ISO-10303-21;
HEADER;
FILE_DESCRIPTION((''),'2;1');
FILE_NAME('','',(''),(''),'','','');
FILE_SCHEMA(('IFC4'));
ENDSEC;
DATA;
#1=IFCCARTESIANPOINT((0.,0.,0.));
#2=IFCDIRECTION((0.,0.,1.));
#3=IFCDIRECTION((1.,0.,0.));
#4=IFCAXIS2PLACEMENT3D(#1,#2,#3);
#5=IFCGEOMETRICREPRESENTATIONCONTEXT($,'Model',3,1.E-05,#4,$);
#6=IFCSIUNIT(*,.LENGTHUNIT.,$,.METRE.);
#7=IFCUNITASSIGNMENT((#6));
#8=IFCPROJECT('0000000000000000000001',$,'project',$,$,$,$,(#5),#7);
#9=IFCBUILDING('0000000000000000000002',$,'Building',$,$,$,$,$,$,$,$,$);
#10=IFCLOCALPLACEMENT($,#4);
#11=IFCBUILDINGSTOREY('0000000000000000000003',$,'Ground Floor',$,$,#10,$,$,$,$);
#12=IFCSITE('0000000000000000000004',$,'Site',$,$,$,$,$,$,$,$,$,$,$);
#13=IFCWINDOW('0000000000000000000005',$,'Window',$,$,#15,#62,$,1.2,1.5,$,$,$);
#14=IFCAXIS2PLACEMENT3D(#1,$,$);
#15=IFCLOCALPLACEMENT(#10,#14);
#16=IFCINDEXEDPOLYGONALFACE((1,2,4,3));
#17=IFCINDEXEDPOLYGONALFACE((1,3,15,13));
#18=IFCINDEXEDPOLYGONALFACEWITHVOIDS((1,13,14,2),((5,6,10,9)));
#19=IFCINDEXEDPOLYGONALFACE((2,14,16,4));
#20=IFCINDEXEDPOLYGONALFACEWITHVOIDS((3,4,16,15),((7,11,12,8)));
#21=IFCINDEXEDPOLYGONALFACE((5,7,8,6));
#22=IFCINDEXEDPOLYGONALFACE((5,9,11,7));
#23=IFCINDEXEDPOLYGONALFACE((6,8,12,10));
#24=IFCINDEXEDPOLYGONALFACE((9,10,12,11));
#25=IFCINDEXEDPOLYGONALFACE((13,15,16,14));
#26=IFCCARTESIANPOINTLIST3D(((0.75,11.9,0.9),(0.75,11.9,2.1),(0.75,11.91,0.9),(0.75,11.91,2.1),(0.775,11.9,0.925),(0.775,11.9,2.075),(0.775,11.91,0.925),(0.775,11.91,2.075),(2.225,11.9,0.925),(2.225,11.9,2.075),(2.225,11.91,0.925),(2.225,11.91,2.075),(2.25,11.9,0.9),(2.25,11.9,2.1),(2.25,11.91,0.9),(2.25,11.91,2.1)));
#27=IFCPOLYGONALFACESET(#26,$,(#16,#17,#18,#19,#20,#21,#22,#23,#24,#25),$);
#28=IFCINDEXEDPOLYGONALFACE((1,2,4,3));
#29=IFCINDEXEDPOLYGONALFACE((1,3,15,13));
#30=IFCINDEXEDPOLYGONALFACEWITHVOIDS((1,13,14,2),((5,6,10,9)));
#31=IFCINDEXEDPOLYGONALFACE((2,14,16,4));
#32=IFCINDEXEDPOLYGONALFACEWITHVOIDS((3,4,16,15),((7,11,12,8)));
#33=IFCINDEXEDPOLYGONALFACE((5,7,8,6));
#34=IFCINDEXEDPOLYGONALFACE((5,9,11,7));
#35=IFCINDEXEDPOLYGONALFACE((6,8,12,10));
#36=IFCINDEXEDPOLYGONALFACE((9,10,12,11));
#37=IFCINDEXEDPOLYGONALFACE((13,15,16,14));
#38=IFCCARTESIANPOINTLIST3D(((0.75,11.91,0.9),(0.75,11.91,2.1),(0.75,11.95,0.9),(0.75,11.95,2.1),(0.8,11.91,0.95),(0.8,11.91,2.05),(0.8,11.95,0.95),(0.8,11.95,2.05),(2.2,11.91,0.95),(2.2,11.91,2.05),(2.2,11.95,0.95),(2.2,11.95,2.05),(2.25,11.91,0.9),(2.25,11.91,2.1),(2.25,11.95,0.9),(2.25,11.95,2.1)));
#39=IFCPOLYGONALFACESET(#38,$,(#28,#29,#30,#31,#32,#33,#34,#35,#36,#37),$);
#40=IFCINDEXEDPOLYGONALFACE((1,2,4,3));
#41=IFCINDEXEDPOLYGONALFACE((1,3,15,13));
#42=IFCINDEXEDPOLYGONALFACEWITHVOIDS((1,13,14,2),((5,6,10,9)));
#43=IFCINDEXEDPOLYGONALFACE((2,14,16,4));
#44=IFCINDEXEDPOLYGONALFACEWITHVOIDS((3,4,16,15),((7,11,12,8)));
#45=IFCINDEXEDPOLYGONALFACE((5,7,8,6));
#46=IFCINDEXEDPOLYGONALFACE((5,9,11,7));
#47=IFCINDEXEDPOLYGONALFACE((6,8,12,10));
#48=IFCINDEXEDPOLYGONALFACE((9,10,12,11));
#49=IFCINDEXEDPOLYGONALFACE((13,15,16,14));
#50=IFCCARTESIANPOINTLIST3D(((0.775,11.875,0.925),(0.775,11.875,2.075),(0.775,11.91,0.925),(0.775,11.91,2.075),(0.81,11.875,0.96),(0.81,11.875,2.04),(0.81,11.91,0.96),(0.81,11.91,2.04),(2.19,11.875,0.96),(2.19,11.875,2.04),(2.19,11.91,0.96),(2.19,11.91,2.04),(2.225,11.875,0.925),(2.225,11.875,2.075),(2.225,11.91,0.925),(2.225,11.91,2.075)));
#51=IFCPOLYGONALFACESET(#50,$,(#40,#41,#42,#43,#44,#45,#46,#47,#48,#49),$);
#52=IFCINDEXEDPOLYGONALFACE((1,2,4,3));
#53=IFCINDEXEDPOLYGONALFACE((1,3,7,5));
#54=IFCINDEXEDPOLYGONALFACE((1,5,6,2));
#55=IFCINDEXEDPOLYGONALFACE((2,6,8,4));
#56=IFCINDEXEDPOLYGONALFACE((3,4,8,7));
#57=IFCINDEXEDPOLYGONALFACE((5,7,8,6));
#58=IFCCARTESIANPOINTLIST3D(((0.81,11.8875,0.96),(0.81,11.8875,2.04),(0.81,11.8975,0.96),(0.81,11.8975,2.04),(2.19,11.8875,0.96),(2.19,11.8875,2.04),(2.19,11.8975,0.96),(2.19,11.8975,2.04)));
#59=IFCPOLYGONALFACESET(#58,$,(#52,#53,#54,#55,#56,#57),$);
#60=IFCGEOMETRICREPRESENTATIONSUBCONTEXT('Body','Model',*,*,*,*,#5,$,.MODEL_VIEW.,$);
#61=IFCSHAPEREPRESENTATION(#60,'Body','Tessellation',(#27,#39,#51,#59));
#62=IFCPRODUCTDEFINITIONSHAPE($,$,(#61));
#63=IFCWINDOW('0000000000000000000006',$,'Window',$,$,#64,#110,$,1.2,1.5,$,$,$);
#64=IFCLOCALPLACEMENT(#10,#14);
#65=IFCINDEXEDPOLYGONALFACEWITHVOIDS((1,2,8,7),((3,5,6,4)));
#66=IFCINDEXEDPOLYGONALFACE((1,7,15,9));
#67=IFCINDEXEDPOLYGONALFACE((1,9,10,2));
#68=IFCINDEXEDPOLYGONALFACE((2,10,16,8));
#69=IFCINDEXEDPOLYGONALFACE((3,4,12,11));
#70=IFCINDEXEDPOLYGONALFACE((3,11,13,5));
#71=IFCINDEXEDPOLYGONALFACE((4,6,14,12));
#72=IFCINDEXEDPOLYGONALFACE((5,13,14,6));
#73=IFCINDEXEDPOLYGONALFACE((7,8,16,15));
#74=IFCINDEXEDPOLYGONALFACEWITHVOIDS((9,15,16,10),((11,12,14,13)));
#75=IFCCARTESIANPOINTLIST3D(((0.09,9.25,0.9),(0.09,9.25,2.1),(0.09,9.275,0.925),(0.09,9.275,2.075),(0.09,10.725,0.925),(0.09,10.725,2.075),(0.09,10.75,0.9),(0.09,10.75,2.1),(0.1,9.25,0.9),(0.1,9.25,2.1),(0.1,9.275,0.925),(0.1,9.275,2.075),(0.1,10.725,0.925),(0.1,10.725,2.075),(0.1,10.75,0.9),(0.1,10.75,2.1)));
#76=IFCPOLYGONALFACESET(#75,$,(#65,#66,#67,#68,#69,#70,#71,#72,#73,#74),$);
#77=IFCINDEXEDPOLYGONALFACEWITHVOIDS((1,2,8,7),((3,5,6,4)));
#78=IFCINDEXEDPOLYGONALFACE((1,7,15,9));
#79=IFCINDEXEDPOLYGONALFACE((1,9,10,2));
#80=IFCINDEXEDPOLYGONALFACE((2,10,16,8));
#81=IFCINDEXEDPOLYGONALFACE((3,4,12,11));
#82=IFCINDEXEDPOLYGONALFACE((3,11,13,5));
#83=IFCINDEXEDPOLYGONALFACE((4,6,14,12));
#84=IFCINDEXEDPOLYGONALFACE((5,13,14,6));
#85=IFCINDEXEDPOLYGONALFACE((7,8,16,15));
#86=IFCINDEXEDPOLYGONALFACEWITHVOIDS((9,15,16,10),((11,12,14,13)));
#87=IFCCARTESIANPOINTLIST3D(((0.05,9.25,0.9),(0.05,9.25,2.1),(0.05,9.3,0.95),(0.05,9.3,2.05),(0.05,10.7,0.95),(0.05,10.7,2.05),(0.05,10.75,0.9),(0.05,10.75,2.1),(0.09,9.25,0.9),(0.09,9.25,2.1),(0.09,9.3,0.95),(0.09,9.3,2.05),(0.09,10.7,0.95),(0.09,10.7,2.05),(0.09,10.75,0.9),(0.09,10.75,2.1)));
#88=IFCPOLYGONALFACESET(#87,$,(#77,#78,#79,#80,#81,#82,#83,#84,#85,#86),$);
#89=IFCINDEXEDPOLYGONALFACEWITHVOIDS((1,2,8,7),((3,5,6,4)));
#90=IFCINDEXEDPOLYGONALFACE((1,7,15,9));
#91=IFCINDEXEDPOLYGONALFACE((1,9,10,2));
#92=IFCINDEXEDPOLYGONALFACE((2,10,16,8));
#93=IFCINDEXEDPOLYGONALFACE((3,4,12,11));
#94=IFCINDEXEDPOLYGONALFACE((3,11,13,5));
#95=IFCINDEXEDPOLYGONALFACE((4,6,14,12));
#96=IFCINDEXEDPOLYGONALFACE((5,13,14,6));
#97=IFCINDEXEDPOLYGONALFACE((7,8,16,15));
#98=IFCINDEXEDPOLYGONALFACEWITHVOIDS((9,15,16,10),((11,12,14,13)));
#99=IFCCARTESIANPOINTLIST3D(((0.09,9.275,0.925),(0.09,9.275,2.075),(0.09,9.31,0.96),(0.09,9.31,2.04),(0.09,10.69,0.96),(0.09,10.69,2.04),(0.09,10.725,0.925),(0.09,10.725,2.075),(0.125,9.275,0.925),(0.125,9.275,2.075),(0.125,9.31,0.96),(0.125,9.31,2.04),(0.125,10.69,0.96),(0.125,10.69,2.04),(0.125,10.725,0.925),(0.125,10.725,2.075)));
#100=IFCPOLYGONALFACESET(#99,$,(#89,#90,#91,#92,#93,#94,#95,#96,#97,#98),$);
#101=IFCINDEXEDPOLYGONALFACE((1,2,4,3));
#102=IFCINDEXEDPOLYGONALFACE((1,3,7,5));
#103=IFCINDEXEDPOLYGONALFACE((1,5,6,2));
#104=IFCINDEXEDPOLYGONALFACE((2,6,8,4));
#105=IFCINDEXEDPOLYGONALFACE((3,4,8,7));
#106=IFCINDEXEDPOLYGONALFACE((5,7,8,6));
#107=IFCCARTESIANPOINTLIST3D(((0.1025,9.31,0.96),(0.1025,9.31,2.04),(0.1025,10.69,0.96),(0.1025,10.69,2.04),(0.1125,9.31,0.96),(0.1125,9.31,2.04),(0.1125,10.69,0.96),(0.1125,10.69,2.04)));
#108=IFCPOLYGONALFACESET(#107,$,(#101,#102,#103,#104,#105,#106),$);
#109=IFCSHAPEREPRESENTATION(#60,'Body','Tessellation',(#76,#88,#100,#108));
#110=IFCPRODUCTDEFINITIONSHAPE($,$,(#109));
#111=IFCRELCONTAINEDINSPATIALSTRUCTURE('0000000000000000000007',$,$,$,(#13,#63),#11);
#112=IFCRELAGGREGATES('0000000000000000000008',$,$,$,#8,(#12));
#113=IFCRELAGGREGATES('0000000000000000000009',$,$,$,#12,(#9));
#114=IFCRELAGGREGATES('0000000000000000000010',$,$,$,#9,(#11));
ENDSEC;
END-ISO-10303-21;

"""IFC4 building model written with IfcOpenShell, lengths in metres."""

from ifc_helpers import new_model, si_unit, frame, origin_with_axes, place, context, subcontext, project, spatial, line, indexed_curve, outline, extrude, element, save


model = new_model("IFC4")

# Units and contexts
model_context = context("Model", 3, precision=1e-05, world=origin_with_axes())
body_context = subcontext(model_context, "Body", "Model", "MODEL_VIEW")
ifc_project = project(units=[si_unit("LENGTHUNIT", "METRE")], contexts=[model_context])

# Site, building, storey
site = spatial("IfcSite", under=ifc_project, Name="Site")
building = spatial("IfcBuilding", under=site, Name="Building")
storey_placement = place(None, origin_with_axes())
storey = spatial("IfcBuildingStorey", under=building, at=storey_placement, Name="Ground Floor")

# Windows
for number, where, z_axis, x_axis, name in (
    (1, (2.25, 12.0, 0.9), (0.0, 0.0, 1.0), (-1.0, 0.0, 0.0), "Window"),
    (2, (0.0, 10.75, 0.9), (0.0, 0.0, 1.0), (0.0, -1.0, 0.0), "Window"),
):
    element("IfcWindow", number, at=place(storey_placement, frame(where, z_axis=z_axis, x_axis=x_axis)), inside=storey, Name=name, OverallHeight=1.2, OverallWidth=1.5, context=body_context, shape_type="SweptSolid", body=[
        extrude(outline(indexed_curve([(0.0, 0.0), (1.5, 0.0), (1.5, 1.2), (0.0, 1.2)], segments=[line(1, 2, 3, 4, 1)]), holes=[indexed_curve([(0.025, 0.025), (1.475, 0.025), (1.475, 1.175), (0.025, 1.175)], segments=[line(1, 2, 3, 4, 1)])]), frame((0.0, 0.09, 0.0), z_axis=(0.0, -1.0, 0.0), x_axis=(1.0, 0.0, 0.0)), (0.0, 0.0, -1.0), 0.01),
        extrude(outline(indexed_curve([(0.0, 0.0), (1.5, 0.0), (1.5, 1.2), (0.0, 1.2)], segments=[line(1, 2, 3, 4, 1)]), holes=[indexed_curve([(0.05, 0.05), (1.45, 0.05), (1.45, 1.15), (0.05, 1.15)], segments=[line(1, 2, 3, 4, 1)])]), frame((0.0, 0.05, 0.0), z_axis=(0.0, -1.0, 0.0), x_axis=(1.0, 0.0, 0.0)), (0.0, 0.0, -1.0), 0.04),
        extrude(outline(indexed_curve([(0.0, 0.0), (1.45, 0.0), (1.45, 1.15), (0.0, 1.15)], segments=[line(1, 2, 3, 4, 1)]), holes=[indexed_curve([(0.035, 0.035), (1.415, 0.035), (1.415, 1.115), (0.035, 1.115)], segments=[line(1, 2, 3, 4, 1)])]), frame((0.025, 0.09, 0.025), z_axis=(0.0, -1.0, 0.0), x_axis=(1.0, 0.0, 0.0)), (0.0, 0.0, -1.0), 0.035),
        extrude(outline(indexed_curve([(0.035, 0.035), (1.415, 0.035), (1.415, 1.115), (0.035, 1.115)], segments=[line(1, 2, 3, 4, 1)])), frame((0.025, 0.1025, 0.025), z_axis=(0.0, -1.0, 0.0), x_axis=(1.0, 0.0, 0.0)), (0.0, 0.0, -1.0), 0.01),
    ])

save(model, "model.ifc")
